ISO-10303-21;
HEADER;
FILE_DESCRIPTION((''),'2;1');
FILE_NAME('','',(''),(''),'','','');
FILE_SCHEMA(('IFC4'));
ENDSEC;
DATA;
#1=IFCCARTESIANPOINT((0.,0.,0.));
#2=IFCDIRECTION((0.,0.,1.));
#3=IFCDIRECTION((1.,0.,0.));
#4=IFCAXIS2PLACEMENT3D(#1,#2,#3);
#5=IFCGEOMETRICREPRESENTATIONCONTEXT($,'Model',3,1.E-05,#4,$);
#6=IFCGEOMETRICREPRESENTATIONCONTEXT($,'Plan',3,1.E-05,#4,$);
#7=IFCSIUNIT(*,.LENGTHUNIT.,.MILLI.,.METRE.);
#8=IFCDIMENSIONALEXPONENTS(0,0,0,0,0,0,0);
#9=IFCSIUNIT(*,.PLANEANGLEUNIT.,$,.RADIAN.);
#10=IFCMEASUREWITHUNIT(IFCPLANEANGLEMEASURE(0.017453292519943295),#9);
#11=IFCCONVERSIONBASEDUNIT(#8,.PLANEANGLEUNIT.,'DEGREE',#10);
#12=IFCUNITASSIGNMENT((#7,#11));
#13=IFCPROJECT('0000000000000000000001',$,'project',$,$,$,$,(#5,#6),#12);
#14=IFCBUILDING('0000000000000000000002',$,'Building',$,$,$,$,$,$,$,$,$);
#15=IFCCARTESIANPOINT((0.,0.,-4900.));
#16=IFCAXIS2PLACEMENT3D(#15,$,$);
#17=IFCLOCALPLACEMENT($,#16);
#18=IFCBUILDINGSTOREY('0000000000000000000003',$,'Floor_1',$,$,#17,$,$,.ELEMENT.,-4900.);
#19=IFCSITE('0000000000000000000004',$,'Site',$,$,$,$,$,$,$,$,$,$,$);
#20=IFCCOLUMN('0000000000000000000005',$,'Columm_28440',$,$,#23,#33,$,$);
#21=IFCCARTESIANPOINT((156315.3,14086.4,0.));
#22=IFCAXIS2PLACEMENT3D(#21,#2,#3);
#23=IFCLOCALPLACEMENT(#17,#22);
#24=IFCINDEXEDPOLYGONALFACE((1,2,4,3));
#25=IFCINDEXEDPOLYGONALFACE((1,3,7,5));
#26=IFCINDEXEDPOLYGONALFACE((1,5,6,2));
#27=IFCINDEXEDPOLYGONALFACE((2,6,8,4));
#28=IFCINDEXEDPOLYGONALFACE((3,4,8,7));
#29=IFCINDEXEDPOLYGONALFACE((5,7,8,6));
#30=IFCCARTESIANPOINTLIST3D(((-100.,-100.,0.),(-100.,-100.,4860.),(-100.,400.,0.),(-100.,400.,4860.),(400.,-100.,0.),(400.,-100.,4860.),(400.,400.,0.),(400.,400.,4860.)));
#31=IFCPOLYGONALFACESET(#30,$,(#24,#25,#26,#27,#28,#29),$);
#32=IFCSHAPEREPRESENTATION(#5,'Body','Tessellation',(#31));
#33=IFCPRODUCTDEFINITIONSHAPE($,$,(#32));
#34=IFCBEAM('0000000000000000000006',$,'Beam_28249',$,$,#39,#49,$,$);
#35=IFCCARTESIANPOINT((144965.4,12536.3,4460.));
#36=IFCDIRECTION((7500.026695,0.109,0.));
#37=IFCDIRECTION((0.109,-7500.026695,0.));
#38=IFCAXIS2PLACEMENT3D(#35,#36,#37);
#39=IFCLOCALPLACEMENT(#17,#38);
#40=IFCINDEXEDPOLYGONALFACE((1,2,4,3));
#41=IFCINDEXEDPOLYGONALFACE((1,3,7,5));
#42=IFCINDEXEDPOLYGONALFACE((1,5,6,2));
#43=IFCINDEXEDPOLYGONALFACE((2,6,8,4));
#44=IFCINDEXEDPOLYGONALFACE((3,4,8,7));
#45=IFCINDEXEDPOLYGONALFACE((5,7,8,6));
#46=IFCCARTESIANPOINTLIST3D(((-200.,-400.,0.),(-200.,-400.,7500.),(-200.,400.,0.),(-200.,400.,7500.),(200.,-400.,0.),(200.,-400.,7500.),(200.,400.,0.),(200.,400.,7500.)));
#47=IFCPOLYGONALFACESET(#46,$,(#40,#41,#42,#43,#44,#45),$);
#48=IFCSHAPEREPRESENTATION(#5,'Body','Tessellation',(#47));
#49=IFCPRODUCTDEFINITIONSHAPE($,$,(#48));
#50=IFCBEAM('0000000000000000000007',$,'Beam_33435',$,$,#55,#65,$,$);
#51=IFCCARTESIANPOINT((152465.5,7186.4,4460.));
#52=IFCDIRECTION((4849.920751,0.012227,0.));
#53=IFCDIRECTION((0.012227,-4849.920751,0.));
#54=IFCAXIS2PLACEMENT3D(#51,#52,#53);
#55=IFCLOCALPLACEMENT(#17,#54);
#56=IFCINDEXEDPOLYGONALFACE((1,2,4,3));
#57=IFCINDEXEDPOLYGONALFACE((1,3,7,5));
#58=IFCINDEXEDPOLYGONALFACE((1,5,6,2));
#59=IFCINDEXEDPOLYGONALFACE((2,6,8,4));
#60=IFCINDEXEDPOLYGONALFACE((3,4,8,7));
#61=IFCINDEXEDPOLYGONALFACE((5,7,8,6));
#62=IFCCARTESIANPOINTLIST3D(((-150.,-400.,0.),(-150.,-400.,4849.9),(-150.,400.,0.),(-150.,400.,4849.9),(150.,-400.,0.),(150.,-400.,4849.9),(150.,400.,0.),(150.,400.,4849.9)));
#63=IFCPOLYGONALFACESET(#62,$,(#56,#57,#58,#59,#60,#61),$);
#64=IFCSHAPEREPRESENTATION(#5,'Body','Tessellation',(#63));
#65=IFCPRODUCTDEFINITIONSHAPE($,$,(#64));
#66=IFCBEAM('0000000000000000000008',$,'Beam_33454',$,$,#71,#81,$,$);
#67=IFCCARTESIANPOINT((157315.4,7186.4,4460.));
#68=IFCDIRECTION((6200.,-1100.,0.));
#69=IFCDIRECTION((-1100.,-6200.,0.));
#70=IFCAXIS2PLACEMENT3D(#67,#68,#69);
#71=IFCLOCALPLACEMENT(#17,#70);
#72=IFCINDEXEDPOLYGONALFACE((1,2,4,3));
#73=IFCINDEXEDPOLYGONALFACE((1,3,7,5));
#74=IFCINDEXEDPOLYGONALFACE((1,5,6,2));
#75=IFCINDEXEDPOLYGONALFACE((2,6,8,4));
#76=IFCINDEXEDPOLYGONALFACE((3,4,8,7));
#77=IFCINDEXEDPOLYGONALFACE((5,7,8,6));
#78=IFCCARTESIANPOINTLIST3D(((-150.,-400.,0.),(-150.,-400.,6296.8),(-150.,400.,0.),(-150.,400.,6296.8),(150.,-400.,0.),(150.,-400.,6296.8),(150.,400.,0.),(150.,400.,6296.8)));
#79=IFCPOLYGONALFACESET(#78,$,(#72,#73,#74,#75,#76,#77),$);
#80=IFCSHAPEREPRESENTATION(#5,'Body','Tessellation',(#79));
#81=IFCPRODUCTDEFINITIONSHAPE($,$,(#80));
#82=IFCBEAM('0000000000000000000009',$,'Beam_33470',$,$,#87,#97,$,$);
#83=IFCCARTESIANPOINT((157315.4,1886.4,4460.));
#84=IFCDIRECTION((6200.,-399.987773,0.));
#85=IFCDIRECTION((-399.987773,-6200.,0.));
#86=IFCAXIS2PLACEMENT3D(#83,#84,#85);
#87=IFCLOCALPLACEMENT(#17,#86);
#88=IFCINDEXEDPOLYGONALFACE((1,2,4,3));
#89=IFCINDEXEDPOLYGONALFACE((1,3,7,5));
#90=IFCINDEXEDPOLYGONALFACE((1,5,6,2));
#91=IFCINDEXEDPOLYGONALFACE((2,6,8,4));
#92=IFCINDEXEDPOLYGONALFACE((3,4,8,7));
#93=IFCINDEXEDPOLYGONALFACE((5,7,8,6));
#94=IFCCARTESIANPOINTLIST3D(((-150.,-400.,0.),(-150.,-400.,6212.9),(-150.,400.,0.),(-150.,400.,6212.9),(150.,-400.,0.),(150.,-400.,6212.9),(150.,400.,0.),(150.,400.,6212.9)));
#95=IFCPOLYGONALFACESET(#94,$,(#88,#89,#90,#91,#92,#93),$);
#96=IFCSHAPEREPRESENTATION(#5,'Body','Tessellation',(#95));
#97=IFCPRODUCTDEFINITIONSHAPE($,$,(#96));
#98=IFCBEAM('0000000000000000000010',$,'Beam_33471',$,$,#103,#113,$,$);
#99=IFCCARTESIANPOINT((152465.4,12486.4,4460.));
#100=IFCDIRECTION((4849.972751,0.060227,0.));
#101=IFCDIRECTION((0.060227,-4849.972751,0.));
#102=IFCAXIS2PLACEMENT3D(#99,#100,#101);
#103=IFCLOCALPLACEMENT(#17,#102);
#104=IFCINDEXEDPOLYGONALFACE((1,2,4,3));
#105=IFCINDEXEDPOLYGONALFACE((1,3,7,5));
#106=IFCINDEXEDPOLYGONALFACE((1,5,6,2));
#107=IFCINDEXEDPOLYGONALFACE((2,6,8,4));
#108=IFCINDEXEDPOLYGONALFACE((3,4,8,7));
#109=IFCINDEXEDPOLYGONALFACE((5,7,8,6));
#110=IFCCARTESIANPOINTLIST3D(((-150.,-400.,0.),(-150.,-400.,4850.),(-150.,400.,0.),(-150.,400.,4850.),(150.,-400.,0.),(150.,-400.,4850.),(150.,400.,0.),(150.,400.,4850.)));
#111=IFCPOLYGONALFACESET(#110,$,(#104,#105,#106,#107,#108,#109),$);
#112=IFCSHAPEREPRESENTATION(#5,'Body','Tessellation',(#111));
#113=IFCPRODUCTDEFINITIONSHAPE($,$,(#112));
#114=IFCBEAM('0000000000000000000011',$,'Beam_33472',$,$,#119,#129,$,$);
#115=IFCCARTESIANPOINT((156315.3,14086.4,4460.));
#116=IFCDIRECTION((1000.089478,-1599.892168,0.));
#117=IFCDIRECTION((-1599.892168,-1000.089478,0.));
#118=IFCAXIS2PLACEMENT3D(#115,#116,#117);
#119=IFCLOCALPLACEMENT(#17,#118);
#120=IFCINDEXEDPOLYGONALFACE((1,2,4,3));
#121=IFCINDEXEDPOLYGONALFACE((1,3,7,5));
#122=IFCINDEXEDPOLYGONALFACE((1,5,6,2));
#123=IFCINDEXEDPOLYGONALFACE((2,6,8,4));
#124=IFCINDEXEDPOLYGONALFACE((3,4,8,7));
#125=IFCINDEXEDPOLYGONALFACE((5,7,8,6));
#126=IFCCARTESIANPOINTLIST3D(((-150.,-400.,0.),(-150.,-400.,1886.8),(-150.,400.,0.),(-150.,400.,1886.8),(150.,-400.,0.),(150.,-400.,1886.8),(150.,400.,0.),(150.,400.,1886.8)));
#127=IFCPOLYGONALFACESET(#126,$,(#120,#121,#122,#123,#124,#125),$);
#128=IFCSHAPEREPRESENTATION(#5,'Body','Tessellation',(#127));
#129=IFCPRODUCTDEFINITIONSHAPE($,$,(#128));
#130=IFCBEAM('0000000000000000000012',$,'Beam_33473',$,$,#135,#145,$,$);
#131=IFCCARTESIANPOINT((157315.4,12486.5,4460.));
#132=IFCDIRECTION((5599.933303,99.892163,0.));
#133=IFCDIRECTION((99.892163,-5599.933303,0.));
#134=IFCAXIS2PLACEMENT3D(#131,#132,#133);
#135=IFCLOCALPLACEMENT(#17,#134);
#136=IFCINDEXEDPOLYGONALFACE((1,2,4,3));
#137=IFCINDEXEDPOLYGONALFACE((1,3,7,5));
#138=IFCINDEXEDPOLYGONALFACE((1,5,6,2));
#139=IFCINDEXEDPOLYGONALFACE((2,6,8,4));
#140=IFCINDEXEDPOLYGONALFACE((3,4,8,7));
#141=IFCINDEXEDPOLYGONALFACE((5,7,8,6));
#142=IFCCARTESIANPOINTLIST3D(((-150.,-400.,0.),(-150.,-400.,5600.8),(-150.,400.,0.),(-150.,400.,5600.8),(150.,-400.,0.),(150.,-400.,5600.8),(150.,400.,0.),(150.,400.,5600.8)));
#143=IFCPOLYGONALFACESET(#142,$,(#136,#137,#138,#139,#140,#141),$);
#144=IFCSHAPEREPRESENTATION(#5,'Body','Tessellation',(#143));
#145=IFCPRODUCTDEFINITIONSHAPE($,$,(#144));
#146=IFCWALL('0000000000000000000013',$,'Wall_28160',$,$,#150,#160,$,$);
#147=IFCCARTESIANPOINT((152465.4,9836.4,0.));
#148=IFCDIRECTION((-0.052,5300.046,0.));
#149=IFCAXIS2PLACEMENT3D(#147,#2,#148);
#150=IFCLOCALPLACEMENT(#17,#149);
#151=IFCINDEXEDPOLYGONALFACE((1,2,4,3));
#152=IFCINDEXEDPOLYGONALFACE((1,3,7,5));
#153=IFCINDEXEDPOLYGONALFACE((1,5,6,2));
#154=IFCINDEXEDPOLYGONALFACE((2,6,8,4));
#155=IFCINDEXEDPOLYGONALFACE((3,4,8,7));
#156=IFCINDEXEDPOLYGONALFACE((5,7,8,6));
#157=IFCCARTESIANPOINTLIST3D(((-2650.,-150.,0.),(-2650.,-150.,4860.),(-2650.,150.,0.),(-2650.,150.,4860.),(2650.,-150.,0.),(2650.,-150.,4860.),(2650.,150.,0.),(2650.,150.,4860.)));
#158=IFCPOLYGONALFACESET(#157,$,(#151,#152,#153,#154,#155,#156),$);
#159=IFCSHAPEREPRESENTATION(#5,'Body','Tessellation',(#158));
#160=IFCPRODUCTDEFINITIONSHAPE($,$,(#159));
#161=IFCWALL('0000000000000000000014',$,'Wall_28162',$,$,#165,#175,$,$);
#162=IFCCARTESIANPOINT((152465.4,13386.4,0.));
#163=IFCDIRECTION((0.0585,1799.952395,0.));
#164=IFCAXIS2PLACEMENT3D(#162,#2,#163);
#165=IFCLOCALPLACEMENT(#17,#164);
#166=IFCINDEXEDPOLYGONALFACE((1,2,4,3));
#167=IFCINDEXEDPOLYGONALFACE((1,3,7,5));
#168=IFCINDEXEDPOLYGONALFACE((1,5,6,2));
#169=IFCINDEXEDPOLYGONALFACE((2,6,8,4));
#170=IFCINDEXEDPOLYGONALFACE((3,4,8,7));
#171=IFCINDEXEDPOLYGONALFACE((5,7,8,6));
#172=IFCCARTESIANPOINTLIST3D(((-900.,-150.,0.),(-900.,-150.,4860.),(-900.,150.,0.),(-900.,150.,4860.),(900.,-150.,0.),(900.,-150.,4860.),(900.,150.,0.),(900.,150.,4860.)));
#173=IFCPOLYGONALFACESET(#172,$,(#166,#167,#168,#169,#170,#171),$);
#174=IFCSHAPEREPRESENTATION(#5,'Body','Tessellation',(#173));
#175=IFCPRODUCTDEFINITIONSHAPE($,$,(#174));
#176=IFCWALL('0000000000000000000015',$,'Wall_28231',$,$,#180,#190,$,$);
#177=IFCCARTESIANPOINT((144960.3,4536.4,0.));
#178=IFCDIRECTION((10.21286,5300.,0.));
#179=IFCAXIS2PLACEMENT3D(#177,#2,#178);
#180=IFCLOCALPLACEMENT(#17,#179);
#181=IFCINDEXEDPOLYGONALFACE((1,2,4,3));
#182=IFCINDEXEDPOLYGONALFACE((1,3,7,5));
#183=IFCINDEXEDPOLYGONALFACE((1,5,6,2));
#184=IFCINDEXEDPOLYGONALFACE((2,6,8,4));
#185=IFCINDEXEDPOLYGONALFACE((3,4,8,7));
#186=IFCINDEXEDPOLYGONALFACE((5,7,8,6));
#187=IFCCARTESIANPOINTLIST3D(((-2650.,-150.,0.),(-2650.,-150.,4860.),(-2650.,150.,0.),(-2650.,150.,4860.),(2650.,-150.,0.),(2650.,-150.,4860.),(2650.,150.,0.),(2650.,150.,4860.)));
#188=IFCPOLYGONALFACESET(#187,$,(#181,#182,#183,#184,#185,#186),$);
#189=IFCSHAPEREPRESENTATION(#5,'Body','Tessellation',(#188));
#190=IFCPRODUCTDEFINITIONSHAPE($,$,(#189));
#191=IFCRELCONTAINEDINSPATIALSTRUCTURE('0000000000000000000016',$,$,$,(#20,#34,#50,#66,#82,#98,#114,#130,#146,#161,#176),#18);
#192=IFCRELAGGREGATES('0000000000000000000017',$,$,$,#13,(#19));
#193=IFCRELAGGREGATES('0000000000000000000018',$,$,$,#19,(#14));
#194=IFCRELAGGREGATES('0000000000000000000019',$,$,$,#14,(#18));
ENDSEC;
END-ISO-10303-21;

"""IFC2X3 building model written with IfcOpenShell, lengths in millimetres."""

from ifc_helpers import new_model, entity, si_unit, converted_unit, frame, origin_with_axes, origin_2d, place, context, project, spatial, rectangle, extrude, element, save


model = new_model("IFC2X3")

# Units and contexts
model_context = context("Model", 3, precision=1e-05, world=origin_with_axes())
plan_context = context("Plan", 3, precision=1e-05, world=origin_with_axes())
ifc_project = project(units=[si_unit("LENGTHUNIT", "METRE", prefix="MILLI"), converted_unit("PLANEANGLEUNIT", "DEGREE", entity("IfcPlaneAngleMeasure", 0.017453292519943295), si_unit("PLANEANGLEUNIT", "RADIAN"), dimensions=[0, 0, 0, 0, 0, 0, 0])], contexts=[model_context, plan_context])

# Site, building, storey
site = spatial("IfcSite", under=ifc_project, Name="Site")
building = spatial("IfcBuilding", under=site, Name="Building")
storey_placement = place(None, frame((0.0, 0.0, -4900.0)))
storey = spatial("IfcBuildingStorey", under=building, at=storey_placement, Name="Floor_1", CompositionType="ELEMENT", Elevation=-4900.0)

# Column
column_1_placement = place(storey_placement, frame((156315.3, 14086.4, 0.0), z_axis=(0.0, 0.0, 1.0), x_axis=(1.0, 0.0, 0.0)))
element("IfcColumn", 1, at=column_1_placement, inside=storey, Name="Columm_28440", context=model_context, shape_type="SweptSolid", body=[
    extrude(rectangle(XDim=500.0, YDim=500.0, at=origin_2d()), frame((150.0, 150.0, 0.0), z_axis=(0.0, 0.0, 1.0), x_axis=(1.0, 0.0, 0.0)), (0.0, 0.0, 1.0), 4860.0),
])

# Beams
beam_1_placement = place(storey_placement, frame((144965.4, 12536.3, 4460.0), z_axis=(7500.026695, 0.109, 0.0), x_axis=(0.109, -7500.026695, 0.0)))
element("IfcBeam", 2, at=beam_1_placement, inside=storey, Name="Beam_28249", context=model_context, shape_type="SweptSolid", body=[
    extrude(rectangle(XDim=400.0, YDim=800.0, at=origin_2d()), origin_with_axes(), (0.0, 0.0, 1.0), 7500.0),
])
beam_2_placement = place(storey_placement, frame((152465.5, 7186.4, 4460.0), z_axis=(4849.920751, 0.012227, 0.0), x_axis=(0.012227, -4849.920751, 0.0)))
element("IfcBeam", 3, at=beam_2_placement, inside=storey, Name="Beam_33435", context=model_context, shape_type="SweptSolid", body=[
    extrude(rectangle(XDim=300.0, YDim=800.0, at=origin_2d()), origin_with_axes(), (0.0, 0.0, 1.0), 4849.9),
])
beam_3_placement = place(storey_placement, frame((157315.4, 7186.4, 4460.0), z_axis=(6200.0, -1100.0, 0.0), x_axis=(-1100.0, -6200.0, 0.0)))
element("IfcBeam", 4, at=beam_3_placement, inside=storey, Name="Beam_33454", context=model_context, shape_type="SweptSolid", body=[
    extrude(rectangle(XDim=300.0, YDim=800.0, at=origin_2d()), origin_with_axes(), (0.0, 0.0, 1.0), 6296.8),
])
beam_4_placement = place(storey_placement, frame((157315.4, 1886.4, 4460.0), z_axis=(6200.0, -399.987773, 0.0), x_axis=(-399.987773, -6200.0, 0.0)))
element("IfcBeam", 5, at=beam_4_placement, inside=storey, Name="Beam_33470", context=model_context, shape_type="SweptSolid", body=[
    extrude(rectangle(XDim=300.0, YDim=800.0, at=origin_2d()), origin_with_axes(), (0.0, 0.0, 1.0), 6212.9),
])
beam_5_placement = place(storey_placement, frame((152465.4, 12486.4, 4460.0), z_axis=(4849.972751, 0.060227, 0.0), x_axis=(0.060227, -4849.972751, 0.0)))
element("IfcBeam", 6, at=beam_5_placement, inside=storey, Name="Beam_33471", context=model_context, shape_type="SweptSolid", body=[
    extrude(rectangle(XDim=300.0, YDim=800.0, at=origin_2d()), origin_with_axes(), (0.0, 0.0, 1.0), 4850.0),
])
beam_6_placement = place(storey_placement, frame((156315.3, 14086.4, 4460.0), z_axis=(1000.089478, -1599.892168, 0.0), x_axis=(-1599.892168, -1000.089478, 0.0)))
element("IfcBeam", 7, at=beam_6_placement, inside=storey, Name="Beam_33472", context=model_context, shape_type="SweptSolid", body=[
    extrude(rectangle(XDim=300.0, YDim=800.0, at=origin_2d()), origin_with_axes(), (0.0, 0.0, 1.0), 1886.8),
])
beam_7_placement = place(storey_placement, frame((157315.4, 12486.5, 4460.0), z_axis=(5599.933303, 99.892163, 0.0), x_axis=(99.892163, -5599.933303, 0.0)))
element("IfcBeam", 8, at=beam_7_placement, inside=storey, Name="Beam_33473", context=model_context, shape_type="SweptSolid", body=[
    extrude(rectangle(XDim=300.0, YDim=800.0, at=origin_2d()), origin_with_axes(), (0.0, 0.0, 1.0), 5600.8),
])

# Walls
wall_1_placement = place(storey_placement, frame((152465.4, 9836.4, 0.0), z_axis=(0.0, 0.0, 1.0), x_axis=(-0.052, 5300.046, 0.0)))
element("IfcWall", 9, at=wall_1_placement, inside=storey, Name="Wall_28160", context=model_context, shape_type="SweptSolid", body=[
    extrude(rectangle(XDim=5300.0, YDim=300.0, at=origin_2d()), origin_with_axes(), (0.0, 0.0, 1.0), 4860.0),
])
wall_2_placement = place(storey_placement, frame((152465.4, 13386.4, 0.0), z_axis=(0.0, 0.0, 1.0), x_axis=(0.0585, 1799.952395, 0.0)))
element("IfcWall", 10, at=wall_2_placement, inside=storey, Name="Wall_28162", context=model_context, shape_type="SweptSolid", body=[
    extrude(rectangle(XDim=1800.0, YDim=300.0, at=origin_2d()), origin_with_axes(), (0.0, 0.0, 1.0), 4860.0),
])
wall_3_placement = place(storey_placement, frame((144960.3, 4536.4, 0.0), z_axis=(0.0, 0.0, 1.0), x_axis=(10.21286, 5300.0, 0.0)))
element("IfcWall", 11, at=wall_3_placement, inside=storey, Name="Wall_28231", context=model_context, shape_type="SweptSolid", body=[
    extrude(rectangle(XDim=5300.0, YDim=300.0, at=origin_2d()), origin_with_axes(), (0.0, 0.0, 1.0), 4860.0),
])

save(model, "model.ifc")
